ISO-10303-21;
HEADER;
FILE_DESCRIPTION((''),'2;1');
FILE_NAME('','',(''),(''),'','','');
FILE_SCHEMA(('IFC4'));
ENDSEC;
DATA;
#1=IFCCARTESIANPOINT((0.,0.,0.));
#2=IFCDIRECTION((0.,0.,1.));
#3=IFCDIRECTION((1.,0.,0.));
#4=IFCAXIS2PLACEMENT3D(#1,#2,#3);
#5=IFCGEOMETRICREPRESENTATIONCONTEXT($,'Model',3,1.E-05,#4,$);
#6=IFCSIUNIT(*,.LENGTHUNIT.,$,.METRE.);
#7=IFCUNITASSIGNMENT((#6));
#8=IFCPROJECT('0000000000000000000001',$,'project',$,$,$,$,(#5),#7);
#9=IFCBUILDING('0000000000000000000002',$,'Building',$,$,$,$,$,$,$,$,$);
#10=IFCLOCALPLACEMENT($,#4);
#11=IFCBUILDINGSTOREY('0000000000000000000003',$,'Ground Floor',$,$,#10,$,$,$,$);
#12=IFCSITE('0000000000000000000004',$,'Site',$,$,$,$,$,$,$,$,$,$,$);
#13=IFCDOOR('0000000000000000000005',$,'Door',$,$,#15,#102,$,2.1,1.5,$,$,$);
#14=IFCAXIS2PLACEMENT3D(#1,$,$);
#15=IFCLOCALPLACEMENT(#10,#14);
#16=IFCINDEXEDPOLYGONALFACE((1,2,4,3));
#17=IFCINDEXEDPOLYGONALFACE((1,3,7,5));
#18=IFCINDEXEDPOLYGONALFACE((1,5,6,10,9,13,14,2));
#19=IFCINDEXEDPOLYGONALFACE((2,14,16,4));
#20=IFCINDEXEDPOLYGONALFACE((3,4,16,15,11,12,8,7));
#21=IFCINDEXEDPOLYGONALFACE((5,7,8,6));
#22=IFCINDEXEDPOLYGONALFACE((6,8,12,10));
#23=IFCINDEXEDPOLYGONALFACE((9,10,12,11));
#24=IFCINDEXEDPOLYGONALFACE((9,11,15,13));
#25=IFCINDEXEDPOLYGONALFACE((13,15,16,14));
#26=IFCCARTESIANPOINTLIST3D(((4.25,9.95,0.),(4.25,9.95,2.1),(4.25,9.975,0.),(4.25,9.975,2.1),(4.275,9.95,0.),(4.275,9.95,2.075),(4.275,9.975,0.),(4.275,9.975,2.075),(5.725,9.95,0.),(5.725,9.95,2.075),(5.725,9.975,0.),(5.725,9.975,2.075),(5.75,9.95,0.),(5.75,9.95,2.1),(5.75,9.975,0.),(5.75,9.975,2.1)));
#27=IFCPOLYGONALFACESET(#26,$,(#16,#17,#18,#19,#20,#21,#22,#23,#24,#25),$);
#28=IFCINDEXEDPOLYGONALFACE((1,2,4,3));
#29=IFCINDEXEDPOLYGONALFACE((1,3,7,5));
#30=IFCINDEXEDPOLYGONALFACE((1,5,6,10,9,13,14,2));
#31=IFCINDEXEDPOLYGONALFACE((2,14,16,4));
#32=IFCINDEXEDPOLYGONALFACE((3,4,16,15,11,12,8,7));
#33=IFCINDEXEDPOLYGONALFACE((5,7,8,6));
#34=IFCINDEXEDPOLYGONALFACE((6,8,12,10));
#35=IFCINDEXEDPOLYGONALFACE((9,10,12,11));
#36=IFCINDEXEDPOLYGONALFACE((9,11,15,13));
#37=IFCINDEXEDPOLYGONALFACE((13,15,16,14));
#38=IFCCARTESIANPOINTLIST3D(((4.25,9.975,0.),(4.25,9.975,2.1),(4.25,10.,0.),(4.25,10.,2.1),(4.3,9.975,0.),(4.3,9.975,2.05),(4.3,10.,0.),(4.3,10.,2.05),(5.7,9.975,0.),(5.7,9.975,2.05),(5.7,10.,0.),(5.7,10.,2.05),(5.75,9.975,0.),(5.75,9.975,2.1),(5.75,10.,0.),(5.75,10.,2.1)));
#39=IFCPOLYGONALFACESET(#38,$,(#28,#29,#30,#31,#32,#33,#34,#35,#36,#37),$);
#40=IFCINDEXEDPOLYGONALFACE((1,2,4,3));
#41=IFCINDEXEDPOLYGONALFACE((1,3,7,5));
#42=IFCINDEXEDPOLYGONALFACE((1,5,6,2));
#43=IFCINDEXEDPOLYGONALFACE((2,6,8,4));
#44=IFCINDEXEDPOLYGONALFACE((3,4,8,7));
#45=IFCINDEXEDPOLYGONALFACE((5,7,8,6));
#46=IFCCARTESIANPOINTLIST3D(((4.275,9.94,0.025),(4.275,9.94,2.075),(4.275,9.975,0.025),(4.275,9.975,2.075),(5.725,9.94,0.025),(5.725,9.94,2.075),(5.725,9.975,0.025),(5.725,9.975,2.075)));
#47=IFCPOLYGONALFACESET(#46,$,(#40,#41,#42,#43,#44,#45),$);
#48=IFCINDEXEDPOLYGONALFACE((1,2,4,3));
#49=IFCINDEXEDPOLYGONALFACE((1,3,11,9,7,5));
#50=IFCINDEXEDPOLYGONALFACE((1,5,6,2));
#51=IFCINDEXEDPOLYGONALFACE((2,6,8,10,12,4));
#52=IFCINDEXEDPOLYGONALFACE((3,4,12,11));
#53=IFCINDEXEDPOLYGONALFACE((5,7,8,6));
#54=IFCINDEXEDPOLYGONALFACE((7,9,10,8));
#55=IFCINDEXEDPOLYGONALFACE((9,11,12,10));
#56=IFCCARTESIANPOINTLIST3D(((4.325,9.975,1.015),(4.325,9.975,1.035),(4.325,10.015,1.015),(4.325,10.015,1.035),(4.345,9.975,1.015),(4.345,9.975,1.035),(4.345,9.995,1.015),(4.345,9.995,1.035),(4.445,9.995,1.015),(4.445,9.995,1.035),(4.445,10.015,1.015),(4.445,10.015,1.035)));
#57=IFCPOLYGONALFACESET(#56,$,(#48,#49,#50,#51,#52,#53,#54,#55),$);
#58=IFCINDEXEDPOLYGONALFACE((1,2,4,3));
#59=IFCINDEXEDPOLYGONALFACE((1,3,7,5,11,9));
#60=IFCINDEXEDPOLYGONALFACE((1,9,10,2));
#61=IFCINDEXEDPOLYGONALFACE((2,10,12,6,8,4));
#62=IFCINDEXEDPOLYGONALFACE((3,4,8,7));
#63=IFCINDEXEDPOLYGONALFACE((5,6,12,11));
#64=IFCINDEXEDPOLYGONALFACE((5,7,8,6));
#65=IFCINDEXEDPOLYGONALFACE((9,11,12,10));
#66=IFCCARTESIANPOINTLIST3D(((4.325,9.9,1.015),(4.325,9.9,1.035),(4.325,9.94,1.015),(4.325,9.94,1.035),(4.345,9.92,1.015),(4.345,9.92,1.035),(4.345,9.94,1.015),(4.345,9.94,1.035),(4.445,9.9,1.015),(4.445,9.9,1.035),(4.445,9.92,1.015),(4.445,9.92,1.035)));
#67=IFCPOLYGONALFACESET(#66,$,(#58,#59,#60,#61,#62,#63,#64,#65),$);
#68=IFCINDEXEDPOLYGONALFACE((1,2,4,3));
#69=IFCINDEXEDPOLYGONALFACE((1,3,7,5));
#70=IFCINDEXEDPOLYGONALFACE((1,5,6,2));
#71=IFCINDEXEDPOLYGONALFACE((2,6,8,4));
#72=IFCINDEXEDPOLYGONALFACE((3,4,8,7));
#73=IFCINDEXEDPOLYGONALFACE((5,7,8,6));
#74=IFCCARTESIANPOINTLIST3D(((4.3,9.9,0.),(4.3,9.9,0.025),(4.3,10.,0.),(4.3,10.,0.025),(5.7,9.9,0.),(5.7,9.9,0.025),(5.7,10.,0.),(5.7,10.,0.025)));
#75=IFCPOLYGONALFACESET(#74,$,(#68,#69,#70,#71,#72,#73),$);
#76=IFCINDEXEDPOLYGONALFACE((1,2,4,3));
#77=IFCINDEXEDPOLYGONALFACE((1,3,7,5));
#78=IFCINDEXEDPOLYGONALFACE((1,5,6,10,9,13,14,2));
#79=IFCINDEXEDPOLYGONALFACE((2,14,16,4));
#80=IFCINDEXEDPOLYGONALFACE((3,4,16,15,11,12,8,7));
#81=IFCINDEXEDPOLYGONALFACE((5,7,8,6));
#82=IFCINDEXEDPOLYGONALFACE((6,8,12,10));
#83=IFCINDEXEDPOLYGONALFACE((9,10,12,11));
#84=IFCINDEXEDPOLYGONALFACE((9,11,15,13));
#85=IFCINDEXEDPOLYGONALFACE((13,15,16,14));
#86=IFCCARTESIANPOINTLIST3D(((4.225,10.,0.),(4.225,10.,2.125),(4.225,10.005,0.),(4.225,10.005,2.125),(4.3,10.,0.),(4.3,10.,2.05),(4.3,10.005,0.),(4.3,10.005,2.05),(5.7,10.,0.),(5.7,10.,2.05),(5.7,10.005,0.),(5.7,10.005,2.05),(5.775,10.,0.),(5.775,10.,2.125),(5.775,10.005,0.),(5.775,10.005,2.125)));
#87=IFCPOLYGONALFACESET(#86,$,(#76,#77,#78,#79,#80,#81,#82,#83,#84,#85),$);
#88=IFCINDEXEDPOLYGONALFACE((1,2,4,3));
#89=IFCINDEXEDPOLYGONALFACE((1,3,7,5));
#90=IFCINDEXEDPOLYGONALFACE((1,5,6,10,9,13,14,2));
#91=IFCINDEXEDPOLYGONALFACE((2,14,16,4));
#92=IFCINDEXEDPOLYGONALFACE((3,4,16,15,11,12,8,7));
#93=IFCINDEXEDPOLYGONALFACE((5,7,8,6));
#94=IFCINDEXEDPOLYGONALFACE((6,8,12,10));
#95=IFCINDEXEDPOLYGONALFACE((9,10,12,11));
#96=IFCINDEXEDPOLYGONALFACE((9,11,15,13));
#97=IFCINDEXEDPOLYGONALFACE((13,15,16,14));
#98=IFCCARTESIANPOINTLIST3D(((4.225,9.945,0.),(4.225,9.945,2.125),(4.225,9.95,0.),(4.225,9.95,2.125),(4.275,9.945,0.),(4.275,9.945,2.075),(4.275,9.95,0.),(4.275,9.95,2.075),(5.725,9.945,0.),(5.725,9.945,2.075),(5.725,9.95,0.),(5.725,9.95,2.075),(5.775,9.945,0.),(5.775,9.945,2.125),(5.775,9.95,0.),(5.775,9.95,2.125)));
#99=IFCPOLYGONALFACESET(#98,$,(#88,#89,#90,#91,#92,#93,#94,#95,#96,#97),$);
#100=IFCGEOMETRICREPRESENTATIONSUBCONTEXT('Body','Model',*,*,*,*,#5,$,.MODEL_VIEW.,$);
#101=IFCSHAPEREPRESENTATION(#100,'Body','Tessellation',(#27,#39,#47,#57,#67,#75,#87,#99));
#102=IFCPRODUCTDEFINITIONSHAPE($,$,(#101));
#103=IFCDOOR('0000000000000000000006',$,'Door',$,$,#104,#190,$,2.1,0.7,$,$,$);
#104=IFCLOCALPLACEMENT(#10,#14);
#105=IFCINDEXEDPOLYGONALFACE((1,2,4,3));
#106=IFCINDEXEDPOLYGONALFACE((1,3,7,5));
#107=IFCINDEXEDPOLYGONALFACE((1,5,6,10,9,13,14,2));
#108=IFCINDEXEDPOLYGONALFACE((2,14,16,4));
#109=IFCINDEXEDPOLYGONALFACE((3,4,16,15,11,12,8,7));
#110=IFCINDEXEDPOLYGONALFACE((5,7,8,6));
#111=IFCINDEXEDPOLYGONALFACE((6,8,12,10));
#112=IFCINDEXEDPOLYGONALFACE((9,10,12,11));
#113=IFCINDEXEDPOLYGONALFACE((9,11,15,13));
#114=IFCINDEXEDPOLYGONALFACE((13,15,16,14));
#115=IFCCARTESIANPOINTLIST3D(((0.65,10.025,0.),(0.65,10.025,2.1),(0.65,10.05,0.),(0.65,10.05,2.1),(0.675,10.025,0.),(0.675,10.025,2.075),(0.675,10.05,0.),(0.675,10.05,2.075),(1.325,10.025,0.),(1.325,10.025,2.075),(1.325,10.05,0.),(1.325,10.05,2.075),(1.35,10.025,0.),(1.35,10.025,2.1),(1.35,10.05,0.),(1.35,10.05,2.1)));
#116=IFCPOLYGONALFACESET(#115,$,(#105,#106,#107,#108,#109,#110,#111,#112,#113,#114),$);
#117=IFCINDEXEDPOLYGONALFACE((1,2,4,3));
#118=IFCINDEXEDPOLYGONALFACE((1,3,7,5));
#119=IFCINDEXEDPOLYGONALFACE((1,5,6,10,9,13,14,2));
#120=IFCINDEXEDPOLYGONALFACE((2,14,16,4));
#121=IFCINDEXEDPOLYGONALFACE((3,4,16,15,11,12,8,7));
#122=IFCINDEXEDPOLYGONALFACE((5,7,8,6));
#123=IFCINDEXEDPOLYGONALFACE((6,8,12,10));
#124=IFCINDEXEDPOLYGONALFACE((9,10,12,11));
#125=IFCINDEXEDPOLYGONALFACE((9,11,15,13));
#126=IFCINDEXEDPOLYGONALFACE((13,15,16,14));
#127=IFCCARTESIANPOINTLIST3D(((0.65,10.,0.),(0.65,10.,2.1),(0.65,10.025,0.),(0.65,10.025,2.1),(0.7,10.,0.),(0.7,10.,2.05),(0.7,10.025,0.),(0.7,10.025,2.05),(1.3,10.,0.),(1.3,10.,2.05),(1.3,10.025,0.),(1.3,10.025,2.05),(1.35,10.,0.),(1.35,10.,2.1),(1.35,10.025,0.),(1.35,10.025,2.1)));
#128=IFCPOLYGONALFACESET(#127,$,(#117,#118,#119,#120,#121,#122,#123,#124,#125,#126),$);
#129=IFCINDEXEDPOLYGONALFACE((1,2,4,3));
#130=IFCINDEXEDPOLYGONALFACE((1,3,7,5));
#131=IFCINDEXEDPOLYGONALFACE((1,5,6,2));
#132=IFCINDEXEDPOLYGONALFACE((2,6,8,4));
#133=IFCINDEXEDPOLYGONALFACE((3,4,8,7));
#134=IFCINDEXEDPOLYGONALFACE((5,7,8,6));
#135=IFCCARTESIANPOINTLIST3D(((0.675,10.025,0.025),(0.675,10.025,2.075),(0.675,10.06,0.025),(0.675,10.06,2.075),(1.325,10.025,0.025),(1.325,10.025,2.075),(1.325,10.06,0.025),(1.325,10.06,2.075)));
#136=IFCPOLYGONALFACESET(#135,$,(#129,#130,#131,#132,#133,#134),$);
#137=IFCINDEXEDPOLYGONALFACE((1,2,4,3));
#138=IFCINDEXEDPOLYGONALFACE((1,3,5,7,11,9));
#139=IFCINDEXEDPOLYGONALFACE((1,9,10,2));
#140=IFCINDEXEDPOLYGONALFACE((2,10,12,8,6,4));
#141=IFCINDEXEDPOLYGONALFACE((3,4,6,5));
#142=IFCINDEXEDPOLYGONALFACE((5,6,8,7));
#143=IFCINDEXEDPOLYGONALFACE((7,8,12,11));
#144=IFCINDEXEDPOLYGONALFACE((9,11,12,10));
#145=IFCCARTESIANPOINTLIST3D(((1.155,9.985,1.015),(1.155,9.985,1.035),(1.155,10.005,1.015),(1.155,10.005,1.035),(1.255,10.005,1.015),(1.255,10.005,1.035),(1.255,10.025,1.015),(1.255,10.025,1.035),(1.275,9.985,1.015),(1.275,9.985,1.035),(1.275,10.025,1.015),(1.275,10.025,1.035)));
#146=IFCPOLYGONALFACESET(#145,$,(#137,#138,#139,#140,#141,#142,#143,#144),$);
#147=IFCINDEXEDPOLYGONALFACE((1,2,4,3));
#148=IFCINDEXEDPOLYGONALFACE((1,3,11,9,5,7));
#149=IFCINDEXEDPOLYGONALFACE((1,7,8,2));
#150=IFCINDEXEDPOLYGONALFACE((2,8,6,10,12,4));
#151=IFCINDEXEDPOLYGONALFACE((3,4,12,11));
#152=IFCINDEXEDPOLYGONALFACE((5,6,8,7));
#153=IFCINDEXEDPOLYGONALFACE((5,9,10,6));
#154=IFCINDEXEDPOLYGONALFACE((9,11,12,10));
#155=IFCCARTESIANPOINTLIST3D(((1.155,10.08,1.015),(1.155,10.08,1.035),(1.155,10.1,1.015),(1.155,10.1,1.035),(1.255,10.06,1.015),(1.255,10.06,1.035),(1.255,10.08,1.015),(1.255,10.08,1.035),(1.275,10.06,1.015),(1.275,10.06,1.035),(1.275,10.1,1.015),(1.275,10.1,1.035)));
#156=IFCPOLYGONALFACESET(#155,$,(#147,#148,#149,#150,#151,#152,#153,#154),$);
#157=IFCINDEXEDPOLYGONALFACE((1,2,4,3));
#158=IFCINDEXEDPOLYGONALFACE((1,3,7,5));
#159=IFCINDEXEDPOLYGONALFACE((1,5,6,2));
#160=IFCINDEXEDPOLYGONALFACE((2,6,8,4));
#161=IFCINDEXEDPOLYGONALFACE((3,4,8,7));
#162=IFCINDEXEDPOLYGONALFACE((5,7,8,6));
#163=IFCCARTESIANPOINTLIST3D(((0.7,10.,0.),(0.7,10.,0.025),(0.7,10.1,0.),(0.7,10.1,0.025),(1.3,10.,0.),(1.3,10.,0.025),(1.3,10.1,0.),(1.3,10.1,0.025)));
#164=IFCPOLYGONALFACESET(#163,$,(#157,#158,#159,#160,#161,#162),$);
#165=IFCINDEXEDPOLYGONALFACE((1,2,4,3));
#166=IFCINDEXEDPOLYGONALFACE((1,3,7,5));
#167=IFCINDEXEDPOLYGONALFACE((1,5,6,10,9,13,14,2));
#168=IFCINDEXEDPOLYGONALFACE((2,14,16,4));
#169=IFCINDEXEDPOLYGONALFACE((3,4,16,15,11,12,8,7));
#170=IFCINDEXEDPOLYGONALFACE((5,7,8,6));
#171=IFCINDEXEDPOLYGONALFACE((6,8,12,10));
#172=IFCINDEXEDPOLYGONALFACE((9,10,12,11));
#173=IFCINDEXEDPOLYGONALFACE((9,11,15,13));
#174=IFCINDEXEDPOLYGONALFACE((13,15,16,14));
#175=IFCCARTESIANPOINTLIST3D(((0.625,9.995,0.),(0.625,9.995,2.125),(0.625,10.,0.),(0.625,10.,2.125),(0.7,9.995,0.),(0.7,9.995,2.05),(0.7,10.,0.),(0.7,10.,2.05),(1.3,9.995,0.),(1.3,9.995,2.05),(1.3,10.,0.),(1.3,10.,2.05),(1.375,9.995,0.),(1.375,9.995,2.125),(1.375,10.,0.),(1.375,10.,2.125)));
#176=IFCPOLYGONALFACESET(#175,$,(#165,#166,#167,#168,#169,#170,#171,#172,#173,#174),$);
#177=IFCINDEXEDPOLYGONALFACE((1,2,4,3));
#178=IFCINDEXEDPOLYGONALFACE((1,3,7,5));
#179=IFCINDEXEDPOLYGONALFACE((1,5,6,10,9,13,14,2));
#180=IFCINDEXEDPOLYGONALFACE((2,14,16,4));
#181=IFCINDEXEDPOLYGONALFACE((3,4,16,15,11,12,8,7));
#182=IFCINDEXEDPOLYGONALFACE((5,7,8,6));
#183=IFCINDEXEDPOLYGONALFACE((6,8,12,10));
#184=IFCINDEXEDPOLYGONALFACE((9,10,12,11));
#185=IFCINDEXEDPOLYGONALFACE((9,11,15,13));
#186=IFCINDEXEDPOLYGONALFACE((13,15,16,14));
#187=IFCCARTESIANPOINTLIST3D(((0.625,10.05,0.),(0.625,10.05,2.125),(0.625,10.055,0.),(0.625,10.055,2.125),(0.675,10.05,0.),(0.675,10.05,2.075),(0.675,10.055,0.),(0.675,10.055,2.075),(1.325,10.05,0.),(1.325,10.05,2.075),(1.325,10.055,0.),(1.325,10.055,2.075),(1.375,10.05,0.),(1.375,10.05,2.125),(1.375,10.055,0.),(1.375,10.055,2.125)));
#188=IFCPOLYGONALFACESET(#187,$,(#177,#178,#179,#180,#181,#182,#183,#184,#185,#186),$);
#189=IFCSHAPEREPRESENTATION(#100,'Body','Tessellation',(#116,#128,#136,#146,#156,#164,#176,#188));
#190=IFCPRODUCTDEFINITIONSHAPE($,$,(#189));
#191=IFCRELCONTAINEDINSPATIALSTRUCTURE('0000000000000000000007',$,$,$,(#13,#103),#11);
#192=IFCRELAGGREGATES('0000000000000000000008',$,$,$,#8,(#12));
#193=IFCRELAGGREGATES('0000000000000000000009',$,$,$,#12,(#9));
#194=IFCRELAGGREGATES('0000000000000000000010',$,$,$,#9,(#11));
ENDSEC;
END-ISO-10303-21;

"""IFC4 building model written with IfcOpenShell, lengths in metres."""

from ifc_helpers import new_model, si_unit, frame, origin_with_axes, place, context, subcontext, project, spatial, line, indexed_curve, outline, extrude, element, save


model = new_model("IFC4")

# Units and contexts
model_context = context("Model", 3, precision=1e-05, world=origin_with_axes())
body_context = subcontext(model_context, "Body", "Model", "MODEL_VIEW")
ifc_project = project(units=[si_unit("LENGTHUNIT", "METRE")], contexts=[model_context])

# Site, building, storey
site = spatial("IfcSite", under=ifc_project, Name="Site")
building = spatial("IfcBuilding", under=site, Name="Building")
storey_placement = place(None, origin_with_axes())
storey = spatial("IfcBuildingStorey", under=building, at=storey_placement, Name="Ground Floor")

# Doors
door_1_placement = place(storey_placement, frame((5.75, 10.0, 0.0), z_axis=(0.0, 0.0, 1.0), x_axis=(-1.0, 0.0, 0.0)))
element("IfcDoor", 1, at=door_1_placement, inside=storey, Name="Door", OverallHeight=2.1, OverallWidth=1.5, context=body_context, shape_type="SweptSolid", body=[
    extrude(outline(indexed_curve([(0.0, 0.0), (0.0, 2.1), (1.5, 2.1), (1.5, 0.0), (1.475, 0.0), (1.475, 2.075), (0.025, 2.075), (0.025, 0.0)], segments=[line(1, 2, 3, 4, 5, 6, 7, 8, 1)])), frame((0.0, 0.025, 0.0), z_axis=(0.0, -1.0, 0.0), x_axis=(1.0, 0.0, 0.0)), (0.0, 0.0, -1.0), 0.025),
    extrude(outline(indexed_curve([(0.0, 0.0), (0.0, 2.1), (1.5, 2.1), (1.5, 0.0), (1.45, 0.0), (1.45, 2.05), (0.05, 2.05), (0.05, 0.0)], segments=[line(1, 2, 3, 4, 5, 6, 7, 8, 1)])), frame((0.0, 0.0, 0.0), z_axis=(0.0, -1.0, 0.0), x_axis=(1.0, 0.0, 0.0)), (0.0, 0.0, -1.0), 0.025),
    extrude(outline(indexed_curve([(0.0, 0.0), (1.45, 0.0), (1.45, 0.035), (0.0, 0.035)], segments=[line(1, 2, 3, 4, 1)])), frame((0.025, 0.025, 0.025), z_axis=(0.0, 0.0, 1.0), x_axis=(1.0, 0.0, 0.0)), (0.0, 0.0, 1.0), 2.05),
    extrude(outline(indexed_curve([(0.0, 0.0), (0.0, -0.04), (-0.12, -0.04), (-0.12, -0.02), (-0.02, -0.02), (-0.02, 0.0)], segments=[line(1, 2, 3, 4, 5, 6, 1)])), frame((1.425, 0.025, 1.015), z_axis=(0.0, 0.0, 1.0), x_axis=(1.0, 0.0, 0.0)), (0.0, 0.0, 1.0), 0.02),
    extrude(outline(indexed_curve([(0.0, 0.0), (0.0, 0.04), (-0.12, 0.04), (-0.12, 0.02), (-0.02, 0.02), (-0.02, 0.0)], segments=[line(1, 2, 3, 4, 5, 6, 1)])), frame((1.425, 0.06, 1.015), z_axis=(0.0, 0.0, 1.0), x_axis=(1.0, 0.0, 0.0)), (0.0, 0.0, 1.0), 0.02),
    extrude(outline(indexed_curve([(0.0, 0.0), (1.4, 0.0), (1.4, 0.1), (0.0, 0.1)], segments=[line(1, 2, 3, 4, 1)])), frame((0.05, 0.0, 0.0), z_axis=(0.0, 0.0, 1.0), x_axis=(1.0, 0.0, 0.0)), (0.0, 0.0, 1.0), 0.025),
    extrude(outline(indexed_curve([(0.0, 0.0), (0.0, 2.125), (1.55, 2.125), (1.55, 0.0), (1.475, 0.0), (1.475, 2.05), (0.075, 2.05), (0.075, 0.0)], segments=[line(1, 2, 3, 4, 5, 6, 7, 8, 1)])), frame((-0.025, -0.005, 0.0), z_axis=(0.0, -1.0, 0.0), x_axis=(1.0, 0.0, 0.0)), (0.0, 0.0, -1.0), 0.005),
    extrude(outline(indexed_curve([(0.0, 0.0), (0.0, 2.125), (1.55, 2.125), (1.55, 0.0), (1.5, 0.0), (1.5, 2.075), (0.05, 2.075), (0.05, 0.0)], segments=[line(1, 2, 3, 4, 5, 6, 7, 8, 1)])), frame((-0.025, 0.05, 0.0), z_axis=(0.0, -1.0, 0.0), x_axis=(1.0, 0.0, 0.0)), (0.0, 0.0, -1.0), 0.005),
])
door_2_placement = place(storey_placement, frame((0.65, 10.0, 0.0), z_axis=(0.0, 0.0, 1.0), x_axis=(1.0, 0.0, 0.0)))
element("IfcDoor", 2, at=door_2_placement, inside=storey, Name="Door", OverallHeight=2.1, OverallWidth=0.7, context=body_context, shape_type="SweptSolid", body=[
    extrude(outline(indexed_curve([(0.0, 0.0), (0.0, 2.1), (0.7, 2.1), (0.7, 0.0), (0.675, 0.0), (0.675, 2.075), (0.025, 2.075), (0.025, 0.0)], segments=[line(1, 2, 3, 4, 5, 6, 7, 8, 1)])), frame((0.0, 0.025, 0.0), z_axis=(0.0, -1.0, 0.0), x_axis=(1.0, 0.0, 0.0)), (0.0, 0.0, -1.0), 0.025),
    extrude(outline(indexed_curve([(0.0, 0.0), (0.0, 2.1), (0.7, 2.1), (0.7, 0.0), (0.65, 0.0), (0.65, 2.05), (0.05, 2.05), (0.05, 0.0)], segments=[line(1, 2, 3, 4, 5, 6, 7, 8, 1)])), frame((0.0, 0.0, 0.0), z_axis=(0.0, -1.0, 0.0), x_axis=(1.0, 0.0, 0.0)), (0.0, 0.0, -1.0), 0.025),
    extrude(outline(indexed_curve([(0.0, 0.0), (0.65, 0.0), (0.65, 0.035), (0.0, 0.035)], segments=[line(1, 2, 3, 4, 1)])), frame((0.025, 0.025, 0.025), z_axis=(0.0, 0.0, 1.0), x_axis=(1.0, 0.0, 0.0)), (0.0, 0.0, 1.0), 2.05),
    extrude(outline(indexed_curve([(0.0, 0.0), (0.0, -0.04), (-0.12, -0.04), (-0.12, -0.02), (-0.02, -0.02), (-0.02, 0.0)], segments=[line(1, 2, 3, 4, 5, 6, 1)])), frame((0.625, 0.025, 1.015), z_axis=(0.0, 0.0, 1.0), x_axis=(1.0, 0.0, 0.0)), (0.0, 0.0, 1.0), 0.02),
    extrude(outline(indexed_curve([(0.0, 0.0), (0.0, 0.04), (-0.12, 0.04), (-0.12, 0.02), (-0.02, 0.02), (-0.02, 0.0)], segments=[line(1, 2, 3, 4, 5, 6, 1)])), frame((0.625, 0.06, 1.015), z_axis=(0.0, 0.0, 1.0), x_axis=(1.0, 0.0, 0.0)), (0.0, 0.0, 1.0), 0.02),
    extrude(outline(indexed_curve([(0.0, 0.0), (0.6, 0.0), (0.6, 0.1), (0.0, 0.1)], segments=[line(1, 2, 3, 4, 1)])), frame((0.05, 0.0, 0.0), z_axis=(0.0, 0.0, 1.0), x_axis=(1.0, 0.0, 0.0)), (0.0, 0.0, 1.0), 0.025),
    extrude(outline(indexed_curve([(0.0, 0.0), (0.0, 2.125), (0.75, 2.125), (0.75, 0.0), (0.675, 0.0), (0.675, 2.05), (0.075, 2.05), (0.075, 0.0)], segments=[line(1, 2, 3, 4, 5, 6, 7, 8, 1)])), frame((-0.025, -0.005, 0.0), z_axis=(0.0, -1.0, 0.0), x_axis=(1.0, 0.0, 0.0)), (0.0, 0.0, -1.0), 0.005),
    extrude(outline(indexed_curve([(0.0, 0.0), (0.0, 2.125), (0.75, 2.125), (0.75, 0.0), (0.7, 0.0), (0.7, 2.075), (0.05, 2.075), (0.05, 0.0)], segments=[line(1, 2, 3, 4, 5, 6, 7, 8, 1)])), frame((-0.025, 0.05, 0.0), z_axis=(0.0, -1.0, 0.0), x_axis=(1.0, 0.0, 0.0)), (0.0, 0.0, -1.0), 0.005),
])

save(model, "model.ifc")
